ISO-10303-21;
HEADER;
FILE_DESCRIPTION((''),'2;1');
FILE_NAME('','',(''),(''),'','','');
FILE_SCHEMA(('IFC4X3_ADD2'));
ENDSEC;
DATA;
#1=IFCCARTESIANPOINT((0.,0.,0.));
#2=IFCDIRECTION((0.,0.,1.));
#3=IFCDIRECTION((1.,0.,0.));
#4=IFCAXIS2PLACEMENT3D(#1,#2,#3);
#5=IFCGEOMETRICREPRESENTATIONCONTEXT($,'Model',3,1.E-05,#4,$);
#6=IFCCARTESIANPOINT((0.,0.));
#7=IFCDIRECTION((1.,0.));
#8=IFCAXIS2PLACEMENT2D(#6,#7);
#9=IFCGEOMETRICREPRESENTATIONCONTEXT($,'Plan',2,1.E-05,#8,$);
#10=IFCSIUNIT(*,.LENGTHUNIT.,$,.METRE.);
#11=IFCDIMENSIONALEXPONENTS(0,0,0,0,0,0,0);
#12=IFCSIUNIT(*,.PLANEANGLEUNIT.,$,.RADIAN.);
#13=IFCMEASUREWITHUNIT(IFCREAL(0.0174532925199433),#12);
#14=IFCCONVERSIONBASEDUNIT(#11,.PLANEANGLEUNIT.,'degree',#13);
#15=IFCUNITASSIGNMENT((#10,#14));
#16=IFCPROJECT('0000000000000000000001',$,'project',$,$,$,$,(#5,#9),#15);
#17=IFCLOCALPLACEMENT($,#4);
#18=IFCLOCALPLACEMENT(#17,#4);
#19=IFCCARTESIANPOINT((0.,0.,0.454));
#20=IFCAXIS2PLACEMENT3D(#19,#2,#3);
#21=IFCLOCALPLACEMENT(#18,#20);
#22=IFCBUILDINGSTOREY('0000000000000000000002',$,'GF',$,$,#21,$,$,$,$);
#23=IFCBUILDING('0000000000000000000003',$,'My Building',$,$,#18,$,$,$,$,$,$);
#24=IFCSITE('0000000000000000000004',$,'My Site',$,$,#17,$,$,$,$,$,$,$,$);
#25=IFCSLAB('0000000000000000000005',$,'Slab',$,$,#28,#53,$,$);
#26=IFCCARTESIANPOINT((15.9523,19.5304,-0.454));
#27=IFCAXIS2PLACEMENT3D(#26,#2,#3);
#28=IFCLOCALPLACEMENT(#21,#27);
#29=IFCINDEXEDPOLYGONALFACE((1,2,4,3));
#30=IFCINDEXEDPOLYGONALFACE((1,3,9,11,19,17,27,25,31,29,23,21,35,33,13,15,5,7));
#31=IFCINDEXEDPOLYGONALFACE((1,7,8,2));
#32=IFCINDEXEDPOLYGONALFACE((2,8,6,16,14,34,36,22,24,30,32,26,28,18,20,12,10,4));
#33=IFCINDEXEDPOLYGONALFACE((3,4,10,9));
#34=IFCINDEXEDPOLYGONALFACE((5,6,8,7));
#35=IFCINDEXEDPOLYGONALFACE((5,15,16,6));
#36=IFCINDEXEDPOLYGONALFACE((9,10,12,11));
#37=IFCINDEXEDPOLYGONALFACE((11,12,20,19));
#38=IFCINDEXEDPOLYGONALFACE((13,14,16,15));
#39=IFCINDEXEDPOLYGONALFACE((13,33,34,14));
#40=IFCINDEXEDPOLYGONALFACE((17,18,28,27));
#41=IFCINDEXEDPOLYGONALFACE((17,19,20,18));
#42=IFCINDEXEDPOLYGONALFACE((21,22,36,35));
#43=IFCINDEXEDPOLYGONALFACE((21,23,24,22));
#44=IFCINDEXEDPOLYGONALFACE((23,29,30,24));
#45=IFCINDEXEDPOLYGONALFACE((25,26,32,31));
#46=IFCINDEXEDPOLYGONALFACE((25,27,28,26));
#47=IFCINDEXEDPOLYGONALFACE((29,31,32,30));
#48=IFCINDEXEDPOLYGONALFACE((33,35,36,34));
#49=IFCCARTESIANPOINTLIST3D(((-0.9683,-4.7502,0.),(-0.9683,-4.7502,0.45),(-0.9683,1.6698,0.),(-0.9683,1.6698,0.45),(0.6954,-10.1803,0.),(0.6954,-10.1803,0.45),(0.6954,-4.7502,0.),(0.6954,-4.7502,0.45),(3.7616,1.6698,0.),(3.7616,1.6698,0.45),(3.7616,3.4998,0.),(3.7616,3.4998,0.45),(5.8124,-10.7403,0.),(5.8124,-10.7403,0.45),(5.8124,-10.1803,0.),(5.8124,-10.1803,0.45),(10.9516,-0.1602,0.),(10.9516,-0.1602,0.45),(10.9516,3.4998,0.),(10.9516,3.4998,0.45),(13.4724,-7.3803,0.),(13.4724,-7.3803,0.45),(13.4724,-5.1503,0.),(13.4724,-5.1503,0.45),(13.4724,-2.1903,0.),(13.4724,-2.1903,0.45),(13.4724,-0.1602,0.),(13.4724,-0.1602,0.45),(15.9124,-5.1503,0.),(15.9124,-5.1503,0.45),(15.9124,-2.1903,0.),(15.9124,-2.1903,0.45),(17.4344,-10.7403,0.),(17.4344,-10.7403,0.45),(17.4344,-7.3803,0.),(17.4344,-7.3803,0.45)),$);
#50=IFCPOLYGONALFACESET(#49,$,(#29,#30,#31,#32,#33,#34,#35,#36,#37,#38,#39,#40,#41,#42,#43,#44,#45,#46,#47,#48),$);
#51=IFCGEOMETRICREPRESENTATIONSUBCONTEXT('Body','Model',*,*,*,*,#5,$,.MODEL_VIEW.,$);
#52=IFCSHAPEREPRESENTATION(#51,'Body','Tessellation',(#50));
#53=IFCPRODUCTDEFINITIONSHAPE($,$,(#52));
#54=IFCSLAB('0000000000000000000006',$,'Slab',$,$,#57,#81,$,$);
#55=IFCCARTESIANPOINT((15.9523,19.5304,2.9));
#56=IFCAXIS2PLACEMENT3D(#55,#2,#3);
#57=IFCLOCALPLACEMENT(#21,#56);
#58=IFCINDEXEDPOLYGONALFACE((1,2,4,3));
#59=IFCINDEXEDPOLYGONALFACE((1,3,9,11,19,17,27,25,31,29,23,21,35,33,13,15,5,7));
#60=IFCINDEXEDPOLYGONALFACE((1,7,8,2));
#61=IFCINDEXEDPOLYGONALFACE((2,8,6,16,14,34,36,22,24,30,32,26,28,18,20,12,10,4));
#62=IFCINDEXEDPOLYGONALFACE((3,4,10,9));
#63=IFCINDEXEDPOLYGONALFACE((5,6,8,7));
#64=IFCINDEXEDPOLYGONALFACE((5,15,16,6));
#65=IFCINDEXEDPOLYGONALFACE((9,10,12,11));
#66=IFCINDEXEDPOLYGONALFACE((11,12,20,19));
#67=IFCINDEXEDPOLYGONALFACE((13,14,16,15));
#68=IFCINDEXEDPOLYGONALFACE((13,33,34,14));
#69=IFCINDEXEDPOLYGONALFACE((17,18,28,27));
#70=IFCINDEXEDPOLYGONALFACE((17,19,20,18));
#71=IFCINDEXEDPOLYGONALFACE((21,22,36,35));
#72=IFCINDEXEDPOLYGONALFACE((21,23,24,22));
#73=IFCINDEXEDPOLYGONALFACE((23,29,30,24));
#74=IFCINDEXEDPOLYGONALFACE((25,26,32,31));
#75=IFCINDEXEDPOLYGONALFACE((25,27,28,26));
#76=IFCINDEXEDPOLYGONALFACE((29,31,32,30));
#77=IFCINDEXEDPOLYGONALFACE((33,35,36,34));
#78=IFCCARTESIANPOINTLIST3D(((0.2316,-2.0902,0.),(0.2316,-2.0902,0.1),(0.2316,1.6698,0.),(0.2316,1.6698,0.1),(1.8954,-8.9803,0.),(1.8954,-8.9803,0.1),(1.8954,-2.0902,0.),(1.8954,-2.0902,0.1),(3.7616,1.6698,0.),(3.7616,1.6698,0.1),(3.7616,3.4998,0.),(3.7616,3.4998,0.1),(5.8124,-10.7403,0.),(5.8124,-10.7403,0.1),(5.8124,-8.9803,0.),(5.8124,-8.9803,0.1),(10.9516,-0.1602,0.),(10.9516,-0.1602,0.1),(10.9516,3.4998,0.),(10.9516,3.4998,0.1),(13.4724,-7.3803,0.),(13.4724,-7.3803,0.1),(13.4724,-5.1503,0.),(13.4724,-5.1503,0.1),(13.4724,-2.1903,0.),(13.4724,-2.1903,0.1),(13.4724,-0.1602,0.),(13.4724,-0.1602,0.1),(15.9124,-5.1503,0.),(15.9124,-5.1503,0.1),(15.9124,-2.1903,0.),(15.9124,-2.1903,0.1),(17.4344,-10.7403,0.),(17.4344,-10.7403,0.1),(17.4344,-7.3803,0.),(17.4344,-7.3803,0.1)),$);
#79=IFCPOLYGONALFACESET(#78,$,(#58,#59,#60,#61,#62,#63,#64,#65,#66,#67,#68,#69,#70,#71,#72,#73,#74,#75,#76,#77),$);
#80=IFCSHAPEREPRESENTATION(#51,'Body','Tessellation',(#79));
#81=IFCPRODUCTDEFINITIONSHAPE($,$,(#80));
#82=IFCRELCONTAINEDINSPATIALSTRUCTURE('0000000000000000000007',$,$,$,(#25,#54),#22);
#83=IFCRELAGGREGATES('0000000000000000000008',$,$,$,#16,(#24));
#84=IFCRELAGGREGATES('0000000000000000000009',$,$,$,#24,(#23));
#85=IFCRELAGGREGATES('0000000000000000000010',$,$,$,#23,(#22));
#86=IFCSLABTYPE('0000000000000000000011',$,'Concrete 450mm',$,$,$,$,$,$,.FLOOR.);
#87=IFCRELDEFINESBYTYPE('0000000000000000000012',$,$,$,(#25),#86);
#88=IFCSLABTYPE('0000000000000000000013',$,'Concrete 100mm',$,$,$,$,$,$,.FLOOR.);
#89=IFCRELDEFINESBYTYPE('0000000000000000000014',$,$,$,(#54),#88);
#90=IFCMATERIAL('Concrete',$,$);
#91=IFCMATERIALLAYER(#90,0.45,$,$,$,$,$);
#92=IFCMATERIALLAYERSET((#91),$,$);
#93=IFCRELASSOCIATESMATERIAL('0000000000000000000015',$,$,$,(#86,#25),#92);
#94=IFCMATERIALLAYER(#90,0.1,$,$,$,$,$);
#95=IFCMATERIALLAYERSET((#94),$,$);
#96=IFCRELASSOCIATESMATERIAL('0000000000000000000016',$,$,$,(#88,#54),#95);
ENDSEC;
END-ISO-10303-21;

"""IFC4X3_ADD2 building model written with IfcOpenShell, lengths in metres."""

from ifc_helpers import new_model, entity, si_unit, converted_unit, frame, origin_with_axes, origin_2d_with_axis, place, context, subcontext, project, spatial, line, indexed_curve, outline, extrude, material, layer, layer_set, layer_usage, type_object, element, save


model = new_model("IFC4X3_ADD2")

# Units and contexts
model_context = context("Model", 3, precision=1e-05, world=origin_with_axes())
plan_context = context("Plan", 2, precision=1e-05, world=origin_2d_with_axis())
body_context_1 = subcontext(model_context, "Body", "Model", "MODEL_VIEW")
ifc_project = project(units=[si_unit("LENGTHUNIT", "METRE"), converted_unit("PLANEANGLEUNIT", "degree", entity("IfcReal", 0.0174532925199433), si_unit("PLANEANGLEUNIT", "RADIAN"), dimensions=[0, 0, 0, 0, 0, 0, 0])], contexts=[model_context, plan_context])

# Site, building, storey
site_placement = place(None, origin_with_axes())
site = spatial("IfcSite", under=ifc_project, at=site_placement, Name="My Site")
building_placement = place(site_placement, origin_with_axes())
building = spatial("IfcBuilding", under=site, at=building_placement, Name="My Building")
storey_placement = place(building_placement, frame((0.0, 0.0, 0.454), z_axis=(0.0, 0.0, 1.0), x_axis=(1.0, 0.0, 0.0)))
storey = spatial("IfcBuildingStorey", under=building, at=storey_placement, Name="GF")

# Slabs
ifc_material_1 = material(Name="Concrete")
ifc_layer_1 = layer(ifc_material_1, 0.45)
ifc_layer_set_1 = layer_set([ifc_layer_1])
ifc_layer_usage_1 = layer_usage(ifc_layer_set_1, "AXIS3", "POSITIVE", 0.0)
slab_type_1 = type_object("IfcSlabType", Name="Concrete 450mm", PredefinedType="FLOOR", material=ifc_layer_set_1)
slab_1_placement = place(storey_placement, frame((15.9523, 19.5304, -0.454), z_axis=(0.0, 0.0, 1.0), x_axis=(1.0, 0.0, 0.0)))
element("IfcSlab", 1, at=slab_1_placement, inside=storey, type_object=slab_type_1, material=ifc_layer_usage_1, Name="Slab", context=body_context_1, shape_type="SweptSolid", body=[
    extrude(outline(indexed_curve([(13.4724, -5.1503), (15.9124, -5.1503), (15.9124, -2.1903), (13.4724, -2.1903), (13.4724, -0.1602), (10.9516, -0.1602), (10.9516, 3.4998), (3.7616, 3.4998), (3.7616, 1.6698), (-0.9683, 1.6698), (-0.9683, -4.7502), (0.6954, -4.7502), (0.6954, -10.1803), (5.8124, -10.1803), (5.8124, -10.7403), (17.4344, -10.7403), (17.4344, -7.3803), (13.4724, -7.3803)], segments=[line(3, 4), line(4, 5), line(5, 6), line(6, 7), line(7, 8), line(8, 9), line(9, 10), line(10, 11), line(11, 12), line(12, 13), line(13, 14), line(14, 15), line(15, 16), line(16, 17), line(17, 18), line(18, 1), line(1, 2), line(2, 3)], self_intersect=False)), None, (0.0, 0.0, 1.0), 0.45),
])
ifc_layer_2 = layer(ifc_material_1, 0.1)
ifc_layer_set_2 = layer_set([ifc_layer_2])
ifc_layer_usage_2 = layer_usage(ifc_layer_set_2, "AXIS3", "POSITIVE", 0.0)
slab_type_2 = type_object("IfcSlabType", Name="Concrete 100mm", PredefinedType="FLOOR", material=ifc_layer_set_2)
slab_2_placement = place(storey_placement, frame((15.9523, 19.5304, 2.9), z_axis=(0.0, 0.0, 1.0), x_axis=(1.0, 0.0, 0.0)))
element("IfcSlab", 2, at=slab_2_placement, inside=storey, type_object=slab_type_2, material=ifc_layer_usage_2, Name="Slab", context=body_context_1, shape_type="SweptSolid", body=[
    extrude(outline(indexed_curve([(10.9516, 3.4998), (10.9516, -0.1602), (13.4724, -0.1602), (13.4724, -2.1903), (15.9124, -2.1903), (15.9124, -5.1503), (13.4724, -5.1503), (13.4724, -7.3803), (17.4344, -7.3803), (17.4344, -10.7403), (5.8124, -10.7403), (5.8124, -8.9803), (1.8954, -8.9803), (1.8954, -2.0902), (0.2316, -2.0902), (0.2316, 1.6698), (3.7616, 1.6698), (3.7616, 3.4998)], segments=[line(12, 11), line(11, 10), line(10, 9), line(9, 8), line(8, 7), line(7, 6), line(6, 5), line(5, 4), line(4, 3), line(3, 2), line(2, 1), line(1, 18), line(18, 17), line(17, 16), line(16, 15), line(15, 14), line(14, 13), line(13, 12)], self_intersect=False)), None, (0.0, 0.0, 1.0), 0.1),
])

save(model, "model.ifc")
